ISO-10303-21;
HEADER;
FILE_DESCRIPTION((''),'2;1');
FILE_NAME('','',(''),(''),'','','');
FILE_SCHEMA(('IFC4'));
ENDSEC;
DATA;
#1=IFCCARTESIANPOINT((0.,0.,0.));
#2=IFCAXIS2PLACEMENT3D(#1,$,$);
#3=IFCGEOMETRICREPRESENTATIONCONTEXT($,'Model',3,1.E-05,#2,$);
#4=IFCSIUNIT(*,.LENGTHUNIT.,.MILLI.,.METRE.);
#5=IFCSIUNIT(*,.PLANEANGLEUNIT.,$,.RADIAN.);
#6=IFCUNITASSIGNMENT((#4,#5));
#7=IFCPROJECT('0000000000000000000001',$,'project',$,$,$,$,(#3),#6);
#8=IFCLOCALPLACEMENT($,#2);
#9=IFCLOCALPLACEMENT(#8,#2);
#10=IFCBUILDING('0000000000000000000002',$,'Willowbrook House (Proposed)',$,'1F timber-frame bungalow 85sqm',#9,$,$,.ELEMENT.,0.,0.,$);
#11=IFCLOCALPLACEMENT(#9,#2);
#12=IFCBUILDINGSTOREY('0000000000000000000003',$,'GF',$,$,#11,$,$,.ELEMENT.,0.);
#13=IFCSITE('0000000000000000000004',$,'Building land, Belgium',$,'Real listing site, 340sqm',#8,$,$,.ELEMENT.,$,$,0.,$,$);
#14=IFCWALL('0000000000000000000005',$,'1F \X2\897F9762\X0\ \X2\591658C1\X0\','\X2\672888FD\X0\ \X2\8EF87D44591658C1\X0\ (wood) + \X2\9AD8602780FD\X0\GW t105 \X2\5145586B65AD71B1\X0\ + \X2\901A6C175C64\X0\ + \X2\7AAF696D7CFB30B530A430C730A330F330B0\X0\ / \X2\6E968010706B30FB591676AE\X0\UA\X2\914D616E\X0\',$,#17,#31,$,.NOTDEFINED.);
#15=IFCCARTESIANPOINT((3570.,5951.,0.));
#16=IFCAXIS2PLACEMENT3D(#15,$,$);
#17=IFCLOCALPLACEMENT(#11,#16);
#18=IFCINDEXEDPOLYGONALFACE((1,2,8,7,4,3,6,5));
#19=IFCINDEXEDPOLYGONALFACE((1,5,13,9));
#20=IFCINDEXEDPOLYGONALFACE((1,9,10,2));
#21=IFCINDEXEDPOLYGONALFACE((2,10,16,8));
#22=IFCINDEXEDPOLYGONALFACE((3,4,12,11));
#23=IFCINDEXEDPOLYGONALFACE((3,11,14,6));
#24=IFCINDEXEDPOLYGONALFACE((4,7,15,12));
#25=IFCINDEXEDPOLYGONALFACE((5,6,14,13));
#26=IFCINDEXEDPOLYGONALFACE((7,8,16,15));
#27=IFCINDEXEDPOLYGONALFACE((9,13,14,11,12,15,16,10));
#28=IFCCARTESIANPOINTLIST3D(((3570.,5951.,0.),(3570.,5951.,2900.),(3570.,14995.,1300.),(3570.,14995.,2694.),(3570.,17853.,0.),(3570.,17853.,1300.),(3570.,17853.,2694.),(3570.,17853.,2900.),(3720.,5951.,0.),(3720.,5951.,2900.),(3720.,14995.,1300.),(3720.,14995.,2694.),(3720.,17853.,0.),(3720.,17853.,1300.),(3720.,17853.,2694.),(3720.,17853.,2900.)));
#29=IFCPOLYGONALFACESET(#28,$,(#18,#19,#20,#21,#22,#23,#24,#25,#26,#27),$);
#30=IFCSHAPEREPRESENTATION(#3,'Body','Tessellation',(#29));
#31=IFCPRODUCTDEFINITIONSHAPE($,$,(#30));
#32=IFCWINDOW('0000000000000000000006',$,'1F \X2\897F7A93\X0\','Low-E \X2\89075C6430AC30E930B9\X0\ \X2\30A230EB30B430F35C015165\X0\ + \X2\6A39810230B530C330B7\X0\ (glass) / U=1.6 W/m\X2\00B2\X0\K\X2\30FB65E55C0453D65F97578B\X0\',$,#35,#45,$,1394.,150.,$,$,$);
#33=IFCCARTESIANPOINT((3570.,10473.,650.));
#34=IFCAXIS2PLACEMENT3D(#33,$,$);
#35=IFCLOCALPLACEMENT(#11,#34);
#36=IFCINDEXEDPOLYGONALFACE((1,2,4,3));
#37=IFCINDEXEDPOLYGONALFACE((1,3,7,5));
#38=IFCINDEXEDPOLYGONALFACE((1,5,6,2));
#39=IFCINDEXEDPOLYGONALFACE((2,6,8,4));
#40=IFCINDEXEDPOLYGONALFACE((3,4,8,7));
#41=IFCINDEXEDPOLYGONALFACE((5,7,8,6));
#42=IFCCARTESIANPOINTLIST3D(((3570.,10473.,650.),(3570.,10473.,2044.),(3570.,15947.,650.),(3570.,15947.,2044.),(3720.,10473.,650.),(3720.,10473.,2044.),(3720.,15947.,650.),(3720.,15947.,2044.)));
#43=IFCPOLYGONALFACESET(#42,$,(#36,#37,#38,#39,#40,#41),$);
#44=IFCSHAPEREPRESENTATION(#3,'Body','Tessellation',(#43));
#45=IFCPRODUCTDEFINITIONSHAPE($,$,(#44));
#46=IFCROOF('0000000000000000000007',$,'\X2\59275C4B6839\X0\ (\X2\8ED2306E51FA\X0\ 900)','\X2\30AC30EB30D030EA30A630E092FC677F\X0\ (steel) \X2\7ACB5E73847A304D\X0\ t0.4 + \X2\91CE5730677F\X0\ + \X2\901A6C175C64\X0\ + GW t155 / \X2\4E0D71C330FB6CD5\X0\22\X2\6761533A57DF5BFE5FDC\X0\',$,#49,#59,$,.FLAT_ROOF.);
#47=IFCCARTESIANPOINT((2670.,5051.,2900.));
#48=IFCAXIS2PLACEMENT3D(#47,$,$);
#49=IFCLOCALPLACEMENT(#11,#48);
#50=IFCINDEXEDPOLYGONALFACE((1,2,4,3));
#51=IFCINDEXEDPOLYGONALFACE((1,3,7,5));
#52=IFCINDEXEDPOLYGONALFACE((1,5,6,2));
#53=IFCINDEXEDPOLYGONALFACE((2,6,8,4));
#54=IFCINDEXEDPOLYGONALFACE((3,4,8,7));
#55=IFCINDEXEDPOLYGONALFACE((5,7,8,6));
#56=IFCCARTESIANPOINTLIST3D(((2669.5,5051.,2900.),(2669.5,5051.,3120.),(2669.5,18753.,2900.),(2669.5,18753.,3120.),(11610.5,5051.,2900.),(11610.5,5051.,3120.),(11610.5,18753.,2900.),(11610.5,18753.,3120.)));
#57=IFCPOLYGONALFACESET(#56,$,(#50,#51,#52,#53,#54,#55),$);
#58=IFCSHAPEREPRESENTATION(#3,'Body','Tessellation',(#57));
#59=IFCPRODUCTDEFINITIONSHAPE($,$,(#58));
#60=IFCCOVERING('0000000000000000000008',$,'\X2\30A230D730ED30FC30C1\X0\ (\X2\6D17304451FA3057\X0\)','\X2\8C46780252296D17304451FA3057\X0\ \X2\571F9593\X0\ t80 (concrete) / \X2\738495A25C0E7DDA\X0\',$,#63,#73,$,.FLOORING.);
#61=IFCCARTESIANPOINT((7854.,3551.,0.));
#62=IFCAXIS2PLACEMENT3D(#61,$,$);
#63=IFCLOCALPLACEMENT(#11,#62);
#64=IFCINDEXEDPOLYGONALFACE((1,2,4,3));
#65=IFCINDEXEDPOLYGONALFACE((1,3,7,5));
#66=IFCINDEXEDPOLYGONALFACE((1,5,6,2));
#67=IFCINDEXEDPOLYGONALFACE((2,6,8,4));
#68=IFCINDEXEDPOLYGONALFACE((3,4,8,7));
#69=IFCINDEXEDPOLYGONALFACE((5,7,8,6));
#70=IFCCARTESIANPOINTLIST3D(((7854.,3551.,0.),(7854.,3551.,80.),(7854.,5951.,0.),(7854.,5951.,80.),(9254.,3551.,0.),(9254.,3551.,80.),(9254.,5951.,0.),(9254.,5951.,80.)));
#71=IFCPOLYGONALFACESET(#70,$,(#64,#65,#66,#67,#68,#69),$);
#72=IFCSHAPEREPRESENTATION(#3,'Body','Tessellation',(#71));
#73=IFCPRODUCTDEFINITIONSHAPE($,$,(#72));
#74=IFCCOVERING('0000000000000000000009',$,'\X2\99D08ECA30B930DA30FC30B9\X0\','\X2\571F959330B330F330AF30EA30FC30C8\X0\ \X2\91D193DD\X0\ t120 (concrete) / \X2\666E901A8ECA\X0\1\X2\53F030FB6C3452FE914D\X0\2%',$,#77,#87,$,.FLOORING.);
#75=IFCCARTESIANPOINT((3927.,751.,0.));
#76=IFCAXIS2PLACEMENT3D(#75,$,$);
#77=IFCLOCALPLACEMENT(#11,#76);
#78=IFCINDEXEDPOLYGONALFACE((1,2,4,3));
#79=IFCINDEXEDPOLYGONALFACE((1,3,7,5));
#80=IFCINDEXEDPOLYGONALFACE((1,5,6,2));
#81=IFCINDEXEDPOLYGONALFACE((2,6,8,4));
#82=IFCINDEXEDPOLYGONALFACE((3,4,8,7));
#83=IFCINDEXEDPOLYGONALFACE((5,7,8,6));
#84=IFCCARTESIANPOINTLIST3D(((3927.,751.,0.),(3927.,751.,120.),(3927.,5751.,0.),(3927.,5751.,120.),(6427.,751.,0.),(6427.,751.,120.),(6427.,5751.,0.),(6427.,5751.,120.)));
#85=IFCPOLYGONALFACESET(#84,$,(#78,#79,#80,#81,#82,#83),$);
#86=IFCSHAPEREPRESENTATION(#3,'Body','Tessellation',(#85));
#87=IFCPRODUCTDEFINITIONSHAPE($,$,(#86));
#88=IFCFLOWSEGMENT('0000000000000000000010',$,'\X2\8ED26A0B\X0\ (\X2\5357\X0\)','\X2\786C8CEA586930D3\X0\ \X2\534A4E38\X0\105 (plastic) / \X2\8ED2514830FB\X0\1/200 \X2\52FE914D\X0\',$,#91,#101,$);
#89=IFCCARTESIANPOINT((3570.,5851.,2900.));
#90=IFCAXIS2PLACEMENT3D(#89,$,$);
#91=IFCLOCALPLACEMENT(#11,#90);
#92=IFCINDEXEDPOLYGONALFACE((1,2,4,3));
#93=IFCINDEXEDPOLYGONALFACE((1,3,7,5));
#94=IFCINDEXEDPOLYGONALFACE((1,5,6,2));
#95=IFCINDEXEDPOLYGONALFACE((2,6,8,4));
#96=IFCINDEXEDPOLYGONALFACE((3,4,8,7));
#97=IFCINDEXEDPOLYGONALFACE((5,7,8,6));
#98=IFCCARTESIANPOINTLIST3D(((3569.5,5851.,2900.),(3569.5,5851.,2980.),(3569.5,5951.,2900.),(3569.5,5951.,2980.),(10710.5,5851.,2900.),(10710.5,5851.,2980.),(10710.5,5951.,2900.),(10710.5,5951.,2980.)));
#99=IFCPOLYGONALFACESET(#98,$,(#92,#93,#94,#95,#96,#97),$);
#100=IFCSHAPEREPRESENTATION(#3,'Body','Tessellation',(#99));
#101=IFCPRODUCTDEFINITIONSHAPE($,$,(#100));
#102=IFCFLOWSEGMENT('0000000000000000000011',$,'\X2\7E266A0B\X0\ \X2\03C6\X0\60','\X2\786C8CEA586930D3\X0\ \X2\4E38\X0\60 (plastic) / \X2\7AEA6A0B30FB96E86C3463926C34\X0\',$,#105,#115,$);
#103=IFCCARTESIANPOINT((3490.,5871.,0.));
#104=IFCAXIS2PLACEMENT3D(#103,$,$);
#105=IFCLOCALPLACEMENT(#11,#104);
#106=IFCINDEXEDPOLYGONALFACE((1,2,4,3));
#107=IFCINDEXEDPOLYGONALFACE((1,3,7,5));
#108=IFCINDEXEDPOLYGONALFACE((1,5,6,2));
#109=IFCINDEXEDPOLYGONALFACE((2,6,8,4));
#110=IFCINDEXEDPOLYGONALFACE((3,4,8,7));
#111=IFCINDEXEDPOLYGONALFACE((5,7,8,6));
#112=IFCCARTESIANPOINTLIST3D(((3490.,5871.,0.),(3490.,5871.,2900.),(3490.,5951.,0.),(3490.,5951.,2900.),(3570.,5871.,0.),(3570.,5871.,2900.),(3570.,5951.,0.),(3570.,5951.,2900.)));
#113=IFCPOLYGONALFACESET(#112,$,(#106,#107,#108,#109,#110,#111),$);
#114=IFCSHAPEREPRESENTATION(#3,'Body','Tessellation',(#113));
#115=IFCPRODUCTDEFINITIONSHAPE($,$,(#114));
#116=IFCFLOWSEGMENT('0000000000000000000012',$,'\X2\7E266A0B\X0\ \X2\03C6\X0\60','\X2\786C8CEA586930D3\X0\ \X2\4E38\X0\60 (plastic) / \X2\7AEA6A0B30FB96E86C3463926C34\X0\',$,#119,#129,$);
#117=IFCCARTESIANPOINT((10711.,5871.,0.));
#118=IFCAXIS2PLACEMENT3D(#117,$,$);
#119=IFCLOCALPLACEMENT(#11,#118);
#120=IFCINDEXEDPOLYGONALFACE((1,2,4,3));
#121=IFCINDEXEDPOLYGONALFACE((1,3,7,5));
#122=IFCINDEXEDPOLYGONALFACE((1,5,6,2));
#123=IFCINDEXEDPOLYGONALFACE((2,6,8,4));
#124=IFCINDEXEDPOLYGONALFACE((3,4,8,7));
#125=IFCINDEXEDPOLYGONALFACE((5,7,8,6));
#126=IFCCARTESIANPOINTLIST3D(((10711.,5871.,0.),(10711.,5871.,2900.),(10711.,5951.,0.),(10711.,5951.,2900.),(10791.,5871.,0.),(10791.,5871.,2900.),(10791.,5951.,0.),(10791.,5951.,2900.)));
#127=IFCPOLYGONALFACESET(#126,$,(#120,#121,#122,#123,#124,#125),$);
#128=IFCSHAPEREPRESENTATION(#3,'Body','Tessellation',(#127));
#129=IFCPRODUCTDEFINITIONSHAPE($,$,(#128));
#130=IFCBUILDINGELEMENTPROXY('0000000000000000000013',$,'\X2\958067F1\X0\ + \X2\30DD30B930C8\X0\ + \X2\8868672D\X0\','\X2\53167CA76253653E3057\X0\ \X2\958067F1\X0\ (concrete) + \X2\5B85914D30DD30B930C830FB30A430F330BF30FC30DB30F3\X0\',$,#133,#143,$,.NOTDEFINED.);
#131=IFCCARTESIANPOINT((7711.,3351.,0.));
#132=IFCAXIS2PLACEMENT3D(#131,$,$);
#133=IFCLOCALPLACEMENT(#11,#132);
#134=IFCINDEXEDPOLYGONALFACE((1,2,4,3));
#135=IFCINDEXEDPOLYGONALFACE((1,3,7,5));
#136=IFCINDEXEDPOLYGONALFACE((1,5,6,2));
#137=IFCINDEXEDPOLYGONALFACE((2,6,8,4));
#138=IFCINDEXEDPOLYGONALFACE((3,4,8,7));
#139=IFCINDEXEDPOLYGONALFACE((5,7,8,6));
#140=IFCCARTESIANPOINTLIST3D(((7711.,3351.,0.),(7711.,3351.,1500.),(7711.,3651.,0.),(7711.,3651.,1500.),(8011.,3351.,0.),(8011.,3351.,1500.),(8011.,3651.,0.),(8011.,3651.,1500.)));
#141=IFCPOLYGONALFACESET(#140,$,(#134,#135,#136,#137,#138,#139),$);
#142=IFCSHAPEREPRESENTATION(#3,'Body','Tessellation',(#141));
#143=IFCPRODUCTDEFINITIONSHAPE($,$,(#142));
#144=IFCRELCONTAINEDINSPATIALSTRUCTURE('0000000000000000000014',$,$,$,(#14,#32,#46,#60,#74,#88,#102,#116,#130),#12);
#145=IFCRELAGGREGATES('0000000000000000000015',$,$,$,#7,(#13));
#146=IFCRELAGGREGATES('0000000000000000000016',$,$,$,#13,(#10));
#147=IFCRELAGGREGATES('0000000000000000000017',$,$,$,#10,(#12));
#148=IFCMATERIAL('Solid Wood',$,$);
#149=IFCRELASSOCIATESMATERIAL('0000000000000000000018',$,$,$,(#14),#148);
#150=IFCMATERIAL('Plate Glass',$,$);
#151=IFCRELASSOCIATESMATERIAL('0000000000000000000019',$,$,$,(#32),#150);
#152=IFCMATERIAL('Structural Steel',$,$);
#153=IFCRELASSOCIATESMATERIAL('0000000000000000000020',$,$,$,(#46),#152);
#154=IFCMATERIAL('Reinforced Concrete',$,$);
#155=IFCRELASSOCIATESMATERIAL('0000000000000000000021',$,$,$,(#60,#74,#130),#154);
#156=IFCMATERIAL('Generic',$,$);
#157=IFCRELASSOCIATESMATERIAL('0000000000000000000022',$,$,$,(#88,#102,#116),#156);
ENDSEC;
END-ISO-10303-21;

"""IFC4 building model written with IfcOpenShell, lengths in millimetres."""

from ifc_helpers import new_model, si_unit, frame, frame_2d, origin, place, context, project, spatial, rectangle, extrude, material, element, fill, save


model = new_model("IFC4")

# Units and contexts
model_context = context("Model", 3, precision=1e-05, world=origin())
ifc_project = project(units=[si_unit("LENGTHUNIT", "METRE", prefix="MILLI"), si_unit("PLANEANGLEUNIT", "RADIAN")], contexts=[model_context])

# Site, building, storey
site_placement = place(None, origin())
site = spatial("IfcSite", under=ifc_project, at=site_placement, Name="Building land, Belgium", ObjectType="Real listing site, 340sqm", CompositionType="ELEMENT", RefElevation=0.0)
building_placement = place(site_placement, origin())
building = spatial("IfcBuilding", under=site, at=building_placement, Name="Willowbrook House (Proposed)", ObjectType="1F timber-frame bungalow 85sqm", CompositionType="ELEMENT", ElevationOfRefHeight=0.0, ElevationOfTerrain=0.0)
storey_placement = place(building_placement, origin())
storey = spatial("IfcBuildingStorey", under=building, at=storey_placement, Name="GF", CompositionType="ELEMENT", Elevation=0.0)

# Shared definitions
ifc_material_1 = material(Name="Solid Wood")

# Shared definitions
ifc_material_2 = material(Name="Reinforced Concrete")

# Shared definitions
ifc_material_3 = material(Name="Plate Glass")

# Wall, opening, window
wall_1_placement = place(storey_placement, frame((3570.0, 5951.0, 0.0)))
wall_1 = element("IfcWall", 1, at=wall_1_placement, inside=storey, material=ifc_material_1, Name="1F 西面 外壁", Description="木製 軸組外壁 (wood) + 高性能GW t105 充填断熱 + 通気層 + 窯業系サイディング / 準耐火・外皮UA配慮", PredefinedType="NOTDEFINED", context=model_context, shape_type="SweptSolid", body=[
    extrude(rectangle(XDim=150.0, YDim=11902.0, at=frame_2d((75.0, 5951.0))), frame((3570.0, 5951.0, 0.0)), (0.0, 0.0, 1.0), 2900.0),
])
opening_1_placement = place(storey_placement, frame((3570.0, 10473.0, 650.0)))
opening_1 = element("IfcOpeningElement", 2, at=opening_1_placement, cuts=wall_1, PredefinedType="NOTDEFINED", context=model_context, shape_type="SweptSolid", body=[
    extrude(rectangle(XDim=150.0, YDim=5474.0, at=frame_2d((75.0, 2737.0))), frame((3570.0, 10473.0, 650.0)), (0.0, 0.0, 1.0), 1394.0),
])
window_1_placement = place(storey_placement, frame((3570.0, 10473.0, 650.0)))
window_1 = element("IfcWindow", 3, at=window_1_placement, inside=storey, material=ifc_material_3, Name="1F 西窓", Description="Low-E 複層ガラス アルゴン封入 + 樹脂サッシ (glass) / U=1.6 W/m²K・日射取得型", OverallHeight=1394.0, OverallWidth=150.0, context=model_context, shape_type="SweptSolid", body=[
    extrude(rectangle(XDim=150.0, YDim=5474.0, at=frame_2d((75.0, 2737.0))), frame((3570.0, 10473.0, 650.0)), (0.0, 0.0, 1.0), 1394.0),
])
fill(opening_1, window_1)

# Roof
ifc_material_4 = material(Name="Structural Steel")
roof_placement = place(storey_placement, frame((2670.0, 5051.0, 2900.0)))
element("IfcRoof", 4, at=roof_placement, inside=storey, material=ifc_material_4, Name="大屋根 (軒の出 900)", Description="ガルバリウム鋼板 (steel) 立平葺き t0.4 + 野地板 + 通気層 + GW t155 / 不燃・法22条区域対応", PredefinedType="FLAT_ROOF", context=model_context, shape_type="SweptSolid", body=[
    extrude(rectangle(XDim=8941.0, YDim=13702.0, at=frame_2d((4470.0, 6851.0))), frame((2670.0, 5051.0, 2900.0)), (0.0, 0.0, 1.0), 220.0),
])

# Coverings
covering_1_placement = place(storey_placement, frame((7854.0, 3551.0, 0.0)))
element("IfcCovering", 5, at=covering_1_placement, inside=storey, material=ifc_material_2, Name="アプローチ (洗い出し)", Description="豆砂利洗い出し 土間 t80 (concrete) / 玄関導線", PredefinedType="FLOORING", context=model_context, shape_type="SweptSolid", body=[
    extrude(rectangle(XDim=1400.0, YDim=2400.0, at=frame_2d((700.0, 1200.0))), frame((7854.0, 3551.0, 0.0)), (0.0, 0.0, 1.0), 80.0),
])
covering_2_placement = place(storey_placement, frame((3927.0, 751.0, 0.0)))
element("IfcCovering", 6, at=covering_2_placement, inside=storey, material=ifc_material_2, Name="駐車スペース", Description="土間コンクリート 金鏝 t120 (concrete) / 普通車1台・水勾配2%", PredefinedType="FLOORING", context=model_context, shape_type="SweptSolid", body=[
    extrude(rectangle(XDim=2500.0, YDim=5000.0, at=frame_2d((1250.0, 2500.0))), frame((3927.0, 751.0, 0.0)), (0.0, 0.0, 1.0), 120.0),
])

# Flow segments
ifc_material_5 = material(Name="Generic")
flow_segment_1_placement = place(storey_placement, frame((3570.0, 5851.0, 2900.0)))
element("IfcFlowSegment", 7, at=flow_segment_1_placement, inside=storey, material=ifc_material_5, Name="軒樋 (南)", Description="硬質塩ビ 半丸105 (plastic) / 軒先・1/200 勾配", context=model_context, shape_type="SweptSolid", body=[
    extrude(rectangle(XDim=7141.0, YDim=100.0, at=frame_2d((3570.0, 50.0))), frame((3570.0, 5851.0, 2900.0)), (0.0, 0.0, 1.0), 80.0),
])
flow_segment_2_placement = place(storey_placement, frame((3490.0, 5871.0, 0.0)))
element("IfcFlowSegment", 8, at=flow_segment_2_placement, inside=storey, material=ifc_material_5, Name="縦樋 φ60", Description="硬質塩ビ 丸60 (plastic) / 竪樋・雨水排水", context=model_context, shape_type="SweptSolid", body=[
    extrude(rectangle(XDim=80.0, YDim=80.0, at=frame_2d((40.0, 40.0))), frame((3490.0, 5871.0, 0.0)), (0.0, 0.0, 1.0), 2900.0),
])
flow_segment_3_placement = place(storey_placement, frame((10711.0, 5871.0, 0.0)))
element("IfcFlowSegment", 9, at=flow_segment_3_placement, inside=storey, material=ifc_material_5, Name="縦樋 φ60", Description="硬質塩ビ 丸60 (plastic) / 竪樋・雨水排水", context=model_context, shape_type="SweptSolid", body=[
    extrude(rectangle(XDim=80.0, YDim=80.0, at=frame_2d((40.0, 40.0))), frame((10711.0, 5871.0, 0.0)), (0.0, 0.0, 1.0), 2900.0),
])

# Building element proxy
proxy_placement = place(storey_placement, frame((7711.0, 3351.0, 0.0)))
element("IfcBuildingElementProxy", 10, at=proxy_placement, inside=storey, material=ifc_material_2, Name="門柱 + ポスト + 表札", Description="化粧打放し 門柱 (concrete) + 宅配ポスト・インターホン", PredefinedType="NOTDEFINED", context=model_context, shape_type="SweptSolid", body=[
    extrude(rectangle(XDim=300.0, YDim=300.0, at=frame_2d((150.0, 150.0))), frame((7711.0, 3351.0, 0.0)), (0.0, 0.0, 1.0), 1500.0),
])

save(model, "model.ifc")
